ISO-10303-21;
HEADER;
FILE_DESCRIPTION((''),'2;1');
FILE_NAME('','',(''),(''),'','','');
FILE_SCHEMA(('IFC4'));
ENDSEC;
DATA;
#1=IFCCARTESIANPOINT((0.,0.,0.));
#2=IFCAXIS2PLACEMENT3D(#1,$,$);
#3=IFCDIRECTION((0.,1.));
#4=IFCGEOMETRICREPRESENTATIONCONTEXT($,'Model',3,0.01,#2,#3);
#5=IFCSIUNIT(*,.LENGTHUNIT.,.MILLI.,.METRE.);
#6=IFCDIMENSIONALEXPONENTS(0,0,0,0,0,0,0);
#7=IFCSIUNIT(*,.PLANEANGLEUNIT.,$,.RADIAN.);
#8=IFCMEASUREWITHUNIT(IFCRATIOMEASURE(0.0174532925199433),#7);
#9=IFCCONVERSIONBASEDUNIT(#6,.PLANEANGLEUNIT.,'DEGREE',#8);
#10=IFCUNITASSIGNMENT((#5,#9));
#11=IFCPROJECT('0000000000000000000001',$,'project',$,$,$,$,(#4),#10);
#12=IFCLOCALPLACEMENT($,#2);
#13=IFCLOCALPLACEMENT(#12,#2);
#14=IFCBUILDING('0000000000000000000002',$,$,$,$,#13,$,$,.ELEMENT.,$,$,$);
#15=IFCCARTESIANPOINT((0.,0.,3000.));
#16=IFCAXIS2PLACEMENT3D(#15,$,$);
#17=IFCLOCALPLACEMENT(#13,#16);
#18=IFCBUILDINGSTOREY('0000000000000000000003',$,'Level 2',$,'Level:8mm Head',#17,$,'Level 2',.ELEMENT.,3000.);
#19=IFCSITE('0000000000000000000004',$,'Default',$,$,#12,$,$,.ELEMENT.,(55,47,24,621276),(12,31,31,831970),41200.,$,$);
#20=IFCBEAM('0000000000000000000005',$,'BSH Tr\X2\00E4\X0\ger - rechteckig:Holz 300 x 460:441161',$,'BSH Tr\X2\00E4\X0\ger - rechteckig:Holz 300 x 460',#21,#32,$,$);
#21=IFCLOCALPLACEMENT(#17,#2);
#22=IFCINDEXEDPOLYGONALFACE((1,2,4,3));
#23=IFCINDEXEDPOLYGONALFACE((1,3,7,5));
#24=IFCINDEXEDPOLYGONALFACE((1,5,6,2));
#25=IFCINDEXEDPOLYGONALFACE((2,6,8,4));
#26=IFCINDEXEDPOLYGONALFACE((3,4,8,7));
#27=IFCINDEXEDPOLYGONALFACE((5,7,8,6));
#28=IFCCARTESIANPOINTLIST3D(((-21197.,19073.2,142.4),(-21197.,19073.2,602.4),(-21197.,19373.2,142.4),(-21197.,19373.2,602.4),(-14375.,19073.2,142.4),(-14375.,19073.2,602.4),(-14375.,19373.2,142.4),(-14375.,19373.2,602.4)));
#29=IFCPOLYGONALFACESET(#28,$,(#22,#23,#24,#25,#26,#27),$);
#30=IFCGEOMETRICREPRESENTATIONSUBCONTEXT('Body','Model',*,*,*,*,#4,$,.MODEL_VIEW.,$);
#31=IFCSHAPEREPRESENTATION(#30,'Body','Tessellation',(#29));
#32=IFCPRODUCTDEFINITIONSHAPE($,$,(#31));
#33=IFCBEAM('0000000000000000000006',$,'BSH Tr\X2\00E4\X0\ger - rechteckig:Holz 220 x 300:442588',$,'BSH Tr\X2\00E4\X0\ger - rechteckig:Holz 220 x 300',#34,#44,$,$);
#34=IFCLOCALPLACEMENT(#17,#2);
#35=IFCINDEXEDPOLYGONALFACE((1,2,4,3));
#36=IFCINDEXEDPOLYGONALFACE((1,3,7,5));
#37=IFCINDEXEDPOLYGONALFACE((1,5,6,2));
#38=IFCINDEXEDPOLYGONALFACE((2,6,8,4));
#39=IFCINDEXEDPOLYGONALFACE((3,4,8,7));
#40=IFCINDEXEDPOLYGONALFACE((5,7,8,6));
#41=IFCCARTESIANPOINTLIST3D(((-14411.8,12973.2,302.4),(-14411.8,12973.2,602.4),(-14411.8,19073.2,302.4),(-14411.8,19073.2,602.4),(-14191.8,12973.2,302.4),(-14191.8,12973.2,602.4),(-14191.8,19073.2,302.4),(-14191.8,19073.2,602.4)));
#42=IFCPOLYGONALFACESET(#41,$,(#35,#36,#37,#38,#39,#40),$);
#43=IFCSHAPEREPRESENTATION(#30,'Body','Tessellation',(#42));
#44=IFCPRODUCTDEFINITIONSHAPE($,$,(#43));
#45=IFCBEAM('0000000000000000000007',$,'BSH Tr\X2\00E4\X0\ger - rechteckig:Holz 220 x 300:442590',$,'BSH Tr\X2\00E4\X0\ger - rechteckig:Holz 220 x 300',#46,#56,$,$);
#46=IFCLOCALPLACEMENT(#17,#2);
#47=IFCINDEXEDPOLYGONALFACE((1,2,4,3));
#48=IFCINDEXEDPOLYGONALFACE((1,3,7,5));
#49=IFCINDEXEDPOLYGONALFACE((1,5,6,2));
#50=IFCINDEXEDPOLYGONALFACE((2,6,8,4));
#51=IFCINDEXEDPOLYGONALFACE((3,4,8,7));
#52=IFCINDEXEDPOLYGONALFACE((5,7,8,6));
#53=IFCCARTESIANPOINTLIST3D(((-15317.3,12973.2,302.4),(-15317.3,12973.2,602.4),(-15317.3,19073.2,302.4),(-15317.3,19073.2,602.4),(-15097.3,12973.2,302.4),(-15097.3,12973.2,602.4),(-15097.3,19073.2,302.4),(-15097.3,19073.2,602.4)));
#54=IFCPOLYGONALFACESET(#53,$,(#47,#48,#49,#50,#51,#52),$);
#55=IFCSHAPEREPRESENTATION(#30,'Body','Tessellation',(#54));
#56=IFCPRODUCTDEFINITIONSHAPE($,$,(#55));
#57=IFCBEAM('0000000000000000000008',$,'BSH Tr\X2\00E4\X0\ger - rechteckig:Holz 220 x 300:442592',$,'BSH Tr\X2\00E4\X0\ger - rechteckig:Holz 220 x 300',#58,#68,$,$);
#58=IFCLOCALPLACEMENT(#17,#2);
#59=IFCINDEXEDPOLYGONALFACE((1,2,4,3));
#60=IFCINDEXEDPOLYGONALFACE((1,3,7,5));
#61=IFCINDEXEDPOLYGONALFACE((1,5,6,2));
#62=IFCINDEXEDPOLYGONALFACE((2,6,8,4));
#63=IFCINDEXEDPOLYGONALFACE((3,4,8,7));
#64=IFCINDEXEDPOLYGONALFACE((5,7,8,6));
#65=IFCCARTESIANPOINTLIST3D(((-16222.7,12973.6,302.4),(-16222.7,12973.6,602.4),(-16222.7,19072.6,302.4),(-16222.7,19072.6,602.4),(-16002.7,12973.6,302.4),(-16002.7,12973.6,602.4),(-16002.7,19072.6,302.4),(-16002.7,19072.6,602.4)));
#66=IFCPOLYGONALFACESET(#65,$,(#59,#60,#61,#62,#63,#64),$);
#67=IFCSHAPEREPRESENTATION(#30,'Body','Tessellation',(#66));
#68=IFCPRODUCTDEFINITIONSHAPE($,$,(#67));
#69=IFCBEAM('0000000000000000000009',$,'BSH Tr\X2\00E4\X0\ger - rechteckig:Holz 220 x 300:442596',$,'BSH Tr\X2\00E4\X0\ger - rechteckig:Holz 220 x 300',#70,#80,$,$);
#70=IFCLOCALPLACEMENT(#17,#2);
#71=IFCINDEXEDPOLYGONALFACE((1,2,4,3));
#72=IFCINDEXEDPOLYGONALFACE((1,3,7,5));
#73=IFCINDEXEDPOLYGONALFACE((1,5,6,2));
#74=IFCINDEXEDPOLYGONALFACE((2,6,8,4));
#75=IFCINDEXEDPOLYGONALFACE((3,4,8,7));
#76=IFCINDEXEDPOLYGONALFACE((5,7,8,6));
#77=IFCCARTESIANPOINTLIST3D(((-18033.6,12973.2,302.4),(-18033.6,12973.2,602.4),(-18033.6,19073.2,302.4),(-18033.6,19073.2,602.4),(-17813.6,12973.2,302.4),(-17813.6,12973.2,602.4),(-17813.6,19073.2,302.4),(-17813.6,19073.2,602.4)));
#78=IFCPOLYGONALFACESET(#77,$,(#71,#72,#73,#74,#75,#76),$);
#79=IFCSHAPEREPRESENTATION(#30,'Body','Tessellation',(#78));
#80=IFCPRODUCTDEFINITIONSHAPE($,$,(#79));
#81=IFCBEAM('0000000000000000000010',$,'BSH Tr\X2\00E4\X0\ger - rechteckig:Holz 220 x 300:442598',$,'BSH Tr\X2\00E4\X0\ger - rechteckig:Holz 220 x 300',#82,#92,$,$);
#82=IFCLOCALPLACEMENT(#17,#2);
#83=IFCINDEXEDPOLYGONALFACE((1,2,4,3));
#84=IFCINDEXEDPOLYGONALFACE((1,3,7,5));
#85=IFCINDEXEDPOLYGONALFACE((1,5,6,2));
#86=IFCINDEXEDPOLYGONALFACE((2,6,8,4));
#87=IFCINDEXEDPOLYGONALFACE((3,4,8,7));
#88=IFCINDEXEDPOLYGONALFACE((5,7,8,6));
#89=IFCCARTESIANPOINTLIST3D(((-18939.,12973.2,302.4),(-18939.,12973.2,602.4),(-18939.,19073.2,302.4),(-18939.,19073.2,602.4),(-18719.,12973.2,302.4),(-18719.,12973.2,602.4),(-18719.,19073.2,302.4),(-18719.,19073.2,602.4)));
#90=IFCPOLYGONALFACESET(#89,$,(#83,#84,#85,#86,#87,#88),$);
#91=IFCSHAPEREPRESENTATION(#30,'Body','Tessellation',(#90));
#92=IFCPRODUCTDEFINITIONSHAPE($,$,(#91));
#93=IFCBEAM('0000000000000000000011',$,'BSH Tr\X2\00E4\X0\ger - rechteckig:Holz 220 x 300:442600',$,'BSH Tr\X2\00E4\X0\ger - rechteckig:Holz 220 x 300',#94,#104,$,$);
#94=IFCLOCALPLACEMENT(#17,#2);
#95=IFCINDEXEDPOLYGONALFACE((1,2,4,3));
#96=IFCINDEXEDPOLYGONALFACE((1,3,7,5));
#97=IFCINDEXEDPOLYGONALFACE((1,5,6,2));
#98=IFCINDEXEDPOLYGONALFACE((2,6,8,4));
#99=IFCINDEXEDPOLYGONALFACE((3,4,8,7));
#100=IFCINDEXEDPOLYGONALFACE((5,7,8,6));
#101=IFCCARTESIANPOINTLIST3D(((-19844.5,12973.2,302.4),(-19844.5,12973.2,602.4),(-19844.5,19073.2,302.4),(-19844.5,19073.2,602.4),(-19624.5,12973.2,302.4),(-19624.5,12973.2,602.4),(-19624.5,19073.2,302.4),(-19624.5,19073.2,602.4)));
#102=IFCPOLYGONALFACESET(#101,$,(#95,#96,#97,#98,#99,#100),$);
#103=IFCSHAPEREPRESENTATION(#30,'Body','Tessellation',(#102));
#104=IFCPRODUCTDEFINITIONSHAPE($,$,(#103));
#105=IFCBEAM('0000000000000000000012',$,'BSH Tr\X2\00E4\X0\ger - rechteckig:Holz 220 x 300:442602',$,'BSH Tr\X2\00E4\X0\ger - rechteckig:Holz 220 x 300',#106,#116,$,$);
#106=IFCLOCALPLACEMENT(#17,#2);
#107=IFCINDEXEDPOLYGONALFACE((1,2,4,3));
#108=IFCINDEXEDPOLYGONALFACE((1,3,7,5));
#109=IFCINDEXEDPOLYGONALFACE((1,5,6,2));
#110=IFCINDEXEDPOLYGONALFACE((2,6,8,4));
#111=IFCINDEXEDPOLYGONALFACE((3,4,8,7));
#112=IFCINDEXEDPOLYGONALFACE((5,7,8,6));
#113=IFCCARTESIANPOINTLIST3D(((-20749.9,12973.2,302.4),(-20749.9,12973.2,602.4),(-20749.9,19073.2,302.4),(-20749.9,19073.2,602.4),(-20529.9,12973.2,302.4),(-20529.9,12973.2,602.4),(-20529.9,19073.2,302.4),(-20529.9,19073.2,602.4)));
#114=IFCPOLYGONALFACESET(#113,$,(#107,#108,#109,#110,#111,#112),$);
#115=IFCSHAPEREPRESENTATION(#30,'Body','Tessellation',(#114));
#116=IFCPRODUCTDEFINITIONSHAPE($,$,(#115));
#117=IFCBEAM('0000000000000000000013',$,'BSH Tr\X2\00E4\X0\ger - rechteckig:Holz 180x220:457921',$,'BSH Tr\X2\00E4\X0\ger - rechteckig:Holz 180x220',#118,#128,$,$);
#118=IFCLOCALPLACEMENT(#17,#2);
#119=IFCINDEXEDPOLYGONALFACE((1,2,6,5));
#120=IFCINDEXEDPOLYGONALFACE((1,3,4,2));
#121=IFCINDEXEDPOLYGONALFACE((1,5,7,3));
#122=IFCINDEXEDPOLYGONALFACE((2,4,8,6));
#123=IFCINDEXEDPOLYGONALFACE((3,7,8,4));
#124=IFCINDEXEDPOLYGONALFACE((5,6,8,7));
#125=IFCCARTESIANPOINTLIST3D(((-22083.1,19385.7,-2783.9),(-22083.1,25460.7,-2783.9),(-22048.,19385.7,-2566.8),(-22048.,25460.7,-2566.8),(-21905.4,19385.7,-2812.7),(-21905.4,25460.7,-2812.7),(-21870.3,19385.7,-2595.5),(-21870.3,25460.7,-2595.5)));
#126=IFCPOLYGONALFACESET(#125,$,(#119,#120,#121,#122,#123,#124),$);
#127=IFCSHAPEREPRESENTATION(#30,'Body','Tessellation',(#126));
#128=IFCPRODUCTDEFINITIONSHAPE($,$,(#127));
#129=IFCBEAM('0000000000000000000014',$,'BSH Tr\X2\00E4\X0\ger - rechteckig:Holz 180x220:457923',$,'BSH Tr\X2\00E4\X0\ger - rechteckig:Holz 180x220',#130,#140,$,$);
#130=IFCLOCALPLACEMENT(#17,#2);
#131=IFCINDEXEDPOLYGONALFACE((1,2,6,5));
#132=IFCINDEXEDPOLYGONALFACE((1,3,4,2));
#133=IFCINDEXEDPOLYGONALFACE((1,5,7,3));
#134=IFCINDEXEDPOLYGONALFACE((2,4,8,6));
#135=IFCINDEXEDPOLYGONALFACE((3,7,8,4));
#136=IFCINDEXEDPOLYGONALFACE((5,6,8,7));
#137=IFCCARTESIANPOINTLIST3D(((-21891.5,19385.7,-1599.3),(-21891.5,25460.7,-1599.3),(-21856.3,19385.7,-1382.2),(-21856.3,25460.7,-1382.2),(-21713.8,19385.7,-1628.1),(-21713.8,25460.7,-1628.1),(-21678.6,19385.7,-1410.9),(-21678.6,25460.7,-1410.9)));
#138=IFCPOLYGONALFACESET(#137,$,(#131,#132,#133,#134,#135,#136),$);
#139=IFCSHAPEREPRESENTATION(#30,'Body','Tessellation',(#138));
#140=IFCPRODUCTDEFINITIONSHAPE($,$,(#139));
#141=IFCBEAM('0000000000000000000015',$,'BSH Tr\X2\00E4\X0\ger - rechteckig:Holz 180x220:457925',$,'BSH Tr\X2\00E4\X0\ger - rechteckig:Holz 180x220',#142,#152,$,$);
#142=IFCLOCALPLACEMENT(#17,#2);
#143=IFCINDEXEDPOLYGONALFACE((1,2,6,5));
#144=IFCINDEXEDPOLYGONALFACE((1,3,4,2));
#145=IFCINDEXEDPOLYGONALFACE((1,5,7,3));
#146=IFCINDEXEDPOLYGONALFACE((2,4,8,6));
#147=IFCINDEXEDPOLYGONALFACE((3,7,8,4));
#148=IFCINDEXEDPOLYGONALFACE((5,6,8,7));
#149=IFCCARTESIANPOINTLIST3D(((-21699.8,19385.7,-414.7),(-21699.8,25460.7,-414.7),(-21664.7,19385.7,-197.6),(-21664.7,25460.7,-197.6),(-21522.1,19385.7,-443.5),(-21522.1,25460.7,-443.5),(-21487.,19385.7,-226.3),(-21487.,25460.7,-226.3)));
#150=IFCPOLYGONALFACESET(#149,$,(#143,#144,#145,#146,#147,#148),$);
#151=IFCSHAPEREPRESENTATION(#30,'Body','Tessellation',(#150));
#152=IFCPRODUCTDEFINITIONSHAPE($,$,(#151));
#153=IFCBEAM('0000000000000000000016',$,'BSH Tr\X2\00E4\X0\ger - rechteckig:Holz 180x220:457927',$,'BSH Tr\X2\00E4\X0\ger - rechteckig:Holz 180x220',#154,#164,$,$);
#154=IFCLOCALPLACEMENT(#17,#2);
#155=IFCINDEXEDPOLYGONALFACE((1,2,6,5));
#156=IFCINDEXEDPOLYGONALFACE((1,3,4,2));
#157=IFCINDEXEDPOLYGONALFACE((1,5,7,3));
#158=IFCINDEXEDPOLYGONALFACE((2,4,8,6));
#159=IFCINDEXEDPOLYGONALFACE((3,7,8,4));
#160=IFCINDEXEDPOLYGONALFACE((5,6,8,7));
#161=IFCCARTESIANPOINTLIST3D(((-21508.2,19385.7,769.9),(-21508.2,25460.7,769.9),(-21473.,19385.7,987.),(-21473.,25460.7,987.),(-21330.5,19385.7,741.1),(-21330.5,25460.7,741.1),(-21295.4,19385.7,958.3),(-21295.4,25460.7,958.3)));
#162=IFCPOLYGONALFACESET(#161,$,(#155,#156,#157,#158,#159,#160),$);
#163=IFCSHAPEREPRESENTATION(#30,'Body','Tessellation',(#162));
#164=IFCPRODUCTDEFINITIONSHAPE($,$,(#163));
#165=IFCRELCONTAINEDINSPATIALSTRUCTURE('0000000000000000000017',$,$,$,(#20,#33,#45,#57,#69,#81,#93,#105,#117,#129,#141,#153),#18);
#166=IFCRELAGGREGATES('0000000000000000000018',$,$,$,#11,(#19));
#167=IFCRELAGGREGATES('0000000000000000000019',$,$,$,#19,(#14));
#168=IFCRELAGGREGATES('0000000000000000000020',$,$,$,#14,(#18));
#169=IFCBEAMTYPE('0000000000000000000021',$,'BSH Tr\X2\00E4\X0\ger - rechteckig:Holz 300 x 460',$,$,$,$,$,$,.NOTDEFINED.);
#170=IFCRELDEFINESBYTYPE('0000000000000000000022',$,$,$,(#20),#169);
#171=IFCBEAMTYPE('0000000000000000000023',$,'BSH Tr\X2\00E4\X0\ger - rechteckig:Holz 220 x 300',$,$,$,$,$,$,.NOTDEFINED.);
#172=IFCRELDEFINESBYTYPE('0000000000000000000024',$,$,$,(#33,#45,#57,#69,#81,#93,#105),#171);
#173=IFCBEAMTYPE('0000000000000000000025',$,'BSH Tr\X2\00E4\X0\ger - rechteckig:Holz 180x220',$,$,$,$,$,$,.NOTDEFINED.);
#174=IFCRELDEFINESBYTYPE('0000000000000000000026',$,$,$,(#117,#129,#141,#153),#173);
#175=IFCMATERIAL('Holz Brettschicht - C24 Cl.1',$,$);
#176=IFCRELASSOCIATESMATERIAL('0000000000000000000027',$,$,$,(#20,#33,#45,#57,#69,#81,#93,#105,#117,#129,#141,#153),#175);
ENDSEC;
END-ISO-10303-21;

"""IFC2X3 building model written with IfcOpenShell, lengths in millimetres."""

from ifc_helpers import new_model, entity, si_unit, converted_unit, direction, frame, frame_2d, origin, origin_2d_with_axis, place, context, subcontext, project, spatial, rectangle, extrude, material, type_object, element, save


model = new_model("IFC2X3")

# Units and contexts
model_context = context("Model", 3, precision=0.01, world=origin(), true_north=direction((0.0, 1.0)))
body_context = subcontext(model_context, "Body", "Model", "MODEL_VIEW")
ifc_project = project(units=[si_unit("LENGTHUNIT", "METRE", prefix="MILLI"), converted_unit("PLANEANGLEUNIT", "DEGREE", entity("IfcRatioMeasure", 0.0174532925199433), si_unit("PLANEANGLEUNIT", "RADIAN"), dimensions=[0, 0, 0, 0, 0, 0, 0])], contexts=[model_context])

# Site, building, storey
site_placement = place(None, origin())
site = spatial("IfcSite", under=ifc_project, at=site_placement, Name="Default", CompositionType="ELEMENT", RefLatitude=(55, 47, 24, 621276), RefLongitude=(12, 31, 31, 831970), RefElevation=41200.0)
building_placement = place(site_placement, origin())
building = spatial("IfcBuilding", under=site, at=building_placement, CompositionType="ELEMENT")
storey_placement = place(building_placement, frame((0.0, 0.0, 3000.0)))
storey = spatial("IfcBuildingStorey", under=building, at=storey_placement, Name="Level 2", ObjectType="Level:8mm Head", LongName="Level 2", CompositionType="ELEMENT", Elevation=3000.0)

# Beams
ifc_material = material(Name="Holz Brettschicht - C24 Cl.1")
beam_type_1 = type_object("IfcBeamType", Name="BSH Träger - rechteckig:Holz 300 x 460", PredefinedType="NOTDEFINED")
beam_1_placement = place(storey_placement, frame((-14041.8, 19223.2, 602.4), z_axis=(0.0, 0.0, 1.0), x_axis=(-1.0, 0.0, 0.0)))
element("IfcBeam", 1, at=beam_1_placement, inside=storey, type_object=beam_type_1, material=ifc_material, Name="BSH Träger - rechteckig:Holz 300 x 460:441161", ObjectType="BSH Träger - rechteckig:Holz 300 x 460", context=body_context, shape_type="SweptSolid", body=[
    extrude(rectangle(XDim=460.0, YDim=300.0, at=frame_2d((0.0, 0.0), x_axis=(1.0, 0.0))), frame((333.2, 0.0, -230.0), z_axis=(1.0, 0.0, 0.0), x_axis=(0.0, 0.0, -1.0)), (0.0, 0.0, 1.0), 6822.0),
])
beam_type_2 = type_object("IfcBeamType", Name="BSH Träger - rechteckig:Holz 220 x 300", PredefinedType="NOTDEFINED")
for number, where, z_axis, x_axis, name in (
    (2, (-14301.8, 19223.2, 602.4), (0.0, 0.0, 1.0), (0.0, -1.0, 0.0), "BSH Träger - rechteckig:Holz 220 x 300:442588"),
    (3, (-15207.3, 19223.2, 602.4), (0.0, 0.0, 1.0), (0.0, -1.0, 0.0), "BSH Träger - rechteckig:Holz 220 x 300:442590"),
):
    element("IfcBeam", number, at=place(storey_placement, frame(where, z_axis=z_axis, x_axis=x_axis)), inside=storey, type_object=beam_type_2, material=ifc_material, Name=name, ObjectType="BSH Träger - rechteckig:Holz 220 x 300", context=body_context, shape_type="SweptSolid", body=[
        extrude(rectangle(XDim=300.0, YDim=220.0, at=frame_2d((0.0, 0.0), x_axis=(1.0, 0.0))), frame((150.0, 0.0, -150.0), z_axis=(1.0, 0.0, 0.0), x_axis=(0.0, 0.0, -1.0)), (0.0, 0.0, 1.0), 6100.0),
    ])
beam_2_placement = place(storey_placement, frame((-16112.7, 19136.0, 602.4), z_axis=(0.0, 0.0, 1.0), x_axis=(0.0, -1.0, 0.0)))
element("IfcBeam", 4, at=beam_2_placement, inside=storey, type_object=beam_type_2, material=ifc_material, Name="BSH Träger - rechteckig:Holz 220 x 300:442592", ObjectType="BSH Träger - rechteckig:Holz 220 x 300", context=body_context, shape_type="SweptSolid", body=[
    extrude(rectangle(XDim=300.0, YDim=220.0, at=frame_2d((0.0, 0.0), x_axis=(1.0, 0.0))), frame((63.4, 0.0, -150.0), z_axis=(1.0, 0.0, 0.0), x_axis=(0.0, 0.0, -1.0)), (0.0, 0.0, 1.0), 6099.0),
])
for number, where, z_axis, x_axis, name in (
    (5, (-17923.6, 19223.2, 602.4), (0.0, 0.0, 1.0), (0.0, -1.0, 0.0), "BSH Träger - rechteckig:Holz 220 x 300:442596"),
    (6, (-18829.0, 19223.2, 602.4), (0.0, 0.0, 1.0), (0.0, -1.0, 0.0), "BSH Träger - rechteckig:Holz 220 x 300:442598"),
):
    element("IfcBeam", number, at=place(storey_placement, frame(where, z_axis=z_axis, x_axis=x_axis)), inside=storey, type_object=beam_type_2, material=ifc_material, Name=name, ObjectType="BSH Träger - rechteckig:Holz 220 x 300", context=body_context, shape_type="SweptSolid", body=[
        extrude(rectangle(XDim=300.0, YDim=220.0, at=frame_2d((0.0, 0.0), x_axis=(1.0, 0.0))), frame((150.0, 0.0, -150.0), z_axis=(1.0, 0.0, 0.0), x_axis=(0.0, 0.0, -1.0)), (0.0, 0.0, 1.0), 6100.0),
    ])
for number, where, z_axis, x_axis, name in (
    (7, (-19734.5, 19223.2, 602.4), (0.0, 0.0, 1.0), (0.0, -1.0, 0.0), "BSH Träger - rechteckig:Holz 220 x 300:442600"),
    (8, (-20639.9, 19223.2, 602.4), (0.0, 0.0, 1.0), (0.0, -1.0, 0.0), "BSH Träger - rechteckig:Holz 220 x 300:442602"),
):
    element("IfcBeam", number, at=place(storey_placement, frame(where, z_axis=z_axis, x_axis=x_axis)), inside=storey, type_object=beam_type_2, material=ifc_material, Name=name, ObjectType="BSH Träger - rechteckig:Holz 220 x 300", context=body_context, shape_type="SweptSolid", body=[
        extrude(rectangle(XDim=300.0, YDim=220.0, at=origin_2d_with_axis()), frame((150.0, 0.0, -150.0), z_axis=(1.0, 0.0, 0.0), x_axis=(0.0, 0.0, -1.0)), (0.0, 0.0, 1.0), 6100.0),
    ])
beam_type_3 = type_object("IfcBeamType", Name="BSH Träger - rechteckig:Holz 180x220", PredefinedType="NOTDEFINED")
beam_3_placement = place(storey_placement, frame((-22048.0, 25023.2, -2566.8), z_axis=(0.0, 0.0, 1.0), x_axis=(0.0, -1.0, 0.0)))
element("IfcBeam", 9, at=beam_3_placement, inside=storey, type_object=beam_type_3, material=ifc_material, Name="BSH Träger - rechteckig:Holz 180x220:457921", ObjectType="BSH Träger - rechteckig:Holz 180x220", context=body_context, shape_type="SweptSolid", body=[
    extrude(rectangle(XDim=220.0, YDim=180.0, at=frame_2d((0.0, 0.0), x_axis=(1.0, 0.0))), frame((-437.5, 71.3, -123.0), z_axis=(1.0, 0.0, 0.0), x_axis=(0.0, 0.159701, 0.987165)), (0.0, 0.0, 1.0), 6075.0),
])
beam_4_placement = place(storey_placement, frame((-21856.3, 25023.2, -1382.2), z_axis=(0.0, 0.0, 1.0), x_axis=(0.0, -1.0, 0.0)))
element("IfcBeam", 10, at=beam_4_placement, inside=storey, type_object=beam_type_3, material=ifc_material, Name="BSH Träger - rechteckig:Holz 180x220:457923", ObjectType="BSH Träger - rechteckig:Holz 180x220", context=body_context, shape_type="SweptSolid", body=[
    extrude(rectangle(XDim=220.0, YDim=180.0, at=frame_2d((0.0, 0.0), x_axis=(1.0, 0.0))), frame((-437.5, 71.3, -123.0), z_axis=(1.0, 0.0, 0.0), x_axis=(0.0, 0.159701, 0.987165)), (0.0, 0.0, 1.0), 6075.0),
])
beam_5_placement = place(storey_placement, frame((-21664.7, 25023.2, -197.6), z_axis=(0.0, 0.0, 1.0), x_axis=(0.0, -1.0, 0.0)))
element("IfcBeam", 11, at=beam_5_placement, inside=storey, type_object=beam_type_3, material=ifc_material, Name="BSH Träger - rechteckig:Holz 180x220:457925", ObjectType="BSH Träger - rechteckig:Holz 180x220", context=body_context, shape_type="SweptSolid", body=[
    extrude(rectangle(XDim=220.0, YDim=180.0, at=frame_2d((0.0, 0.0), x_axis=(1.0, 0.0))), frame((-437.5, 71.3, -123.0), z_axis=(1.0, 0.0, 0.0), x_axis=(0.0, 0.159701, 0.987165)), (0.0, 0.0, 1.0), 6075.0),
])
beam_6_placement = place(storey_placement, frame((-21473.0, 25023.2, 987.0), z_axis=(0.0, 0.0, 1.0), x_axis=(0.0, -1.0, 0.0)))
element("IfcBeam", 12, at=beam_6_placement, inside=storey, type_object=beam_type_3, material=ifc_material, Name="BSH Träger - rechteckig:Holz 180x220:457927", ObjectType="BSH Träger - rechteckig:Holz 180x220", context=body_context, shape_type="SweptSolid", body=[
    extrude(rectangle(XDim=220.0, YDim=180.0, at=frame_2d((0.0, 0.0), x_axis=(1.0, 0.0))), frame((-437.5, 71.3, -123.0), z_axis=(1.0, 0.0, 0.0), x_axis=(0.0, 0.159701, 0.987165)), (0.0, 0.0, 1.0), 6075.0),
])

save(model, "model.ifc")
